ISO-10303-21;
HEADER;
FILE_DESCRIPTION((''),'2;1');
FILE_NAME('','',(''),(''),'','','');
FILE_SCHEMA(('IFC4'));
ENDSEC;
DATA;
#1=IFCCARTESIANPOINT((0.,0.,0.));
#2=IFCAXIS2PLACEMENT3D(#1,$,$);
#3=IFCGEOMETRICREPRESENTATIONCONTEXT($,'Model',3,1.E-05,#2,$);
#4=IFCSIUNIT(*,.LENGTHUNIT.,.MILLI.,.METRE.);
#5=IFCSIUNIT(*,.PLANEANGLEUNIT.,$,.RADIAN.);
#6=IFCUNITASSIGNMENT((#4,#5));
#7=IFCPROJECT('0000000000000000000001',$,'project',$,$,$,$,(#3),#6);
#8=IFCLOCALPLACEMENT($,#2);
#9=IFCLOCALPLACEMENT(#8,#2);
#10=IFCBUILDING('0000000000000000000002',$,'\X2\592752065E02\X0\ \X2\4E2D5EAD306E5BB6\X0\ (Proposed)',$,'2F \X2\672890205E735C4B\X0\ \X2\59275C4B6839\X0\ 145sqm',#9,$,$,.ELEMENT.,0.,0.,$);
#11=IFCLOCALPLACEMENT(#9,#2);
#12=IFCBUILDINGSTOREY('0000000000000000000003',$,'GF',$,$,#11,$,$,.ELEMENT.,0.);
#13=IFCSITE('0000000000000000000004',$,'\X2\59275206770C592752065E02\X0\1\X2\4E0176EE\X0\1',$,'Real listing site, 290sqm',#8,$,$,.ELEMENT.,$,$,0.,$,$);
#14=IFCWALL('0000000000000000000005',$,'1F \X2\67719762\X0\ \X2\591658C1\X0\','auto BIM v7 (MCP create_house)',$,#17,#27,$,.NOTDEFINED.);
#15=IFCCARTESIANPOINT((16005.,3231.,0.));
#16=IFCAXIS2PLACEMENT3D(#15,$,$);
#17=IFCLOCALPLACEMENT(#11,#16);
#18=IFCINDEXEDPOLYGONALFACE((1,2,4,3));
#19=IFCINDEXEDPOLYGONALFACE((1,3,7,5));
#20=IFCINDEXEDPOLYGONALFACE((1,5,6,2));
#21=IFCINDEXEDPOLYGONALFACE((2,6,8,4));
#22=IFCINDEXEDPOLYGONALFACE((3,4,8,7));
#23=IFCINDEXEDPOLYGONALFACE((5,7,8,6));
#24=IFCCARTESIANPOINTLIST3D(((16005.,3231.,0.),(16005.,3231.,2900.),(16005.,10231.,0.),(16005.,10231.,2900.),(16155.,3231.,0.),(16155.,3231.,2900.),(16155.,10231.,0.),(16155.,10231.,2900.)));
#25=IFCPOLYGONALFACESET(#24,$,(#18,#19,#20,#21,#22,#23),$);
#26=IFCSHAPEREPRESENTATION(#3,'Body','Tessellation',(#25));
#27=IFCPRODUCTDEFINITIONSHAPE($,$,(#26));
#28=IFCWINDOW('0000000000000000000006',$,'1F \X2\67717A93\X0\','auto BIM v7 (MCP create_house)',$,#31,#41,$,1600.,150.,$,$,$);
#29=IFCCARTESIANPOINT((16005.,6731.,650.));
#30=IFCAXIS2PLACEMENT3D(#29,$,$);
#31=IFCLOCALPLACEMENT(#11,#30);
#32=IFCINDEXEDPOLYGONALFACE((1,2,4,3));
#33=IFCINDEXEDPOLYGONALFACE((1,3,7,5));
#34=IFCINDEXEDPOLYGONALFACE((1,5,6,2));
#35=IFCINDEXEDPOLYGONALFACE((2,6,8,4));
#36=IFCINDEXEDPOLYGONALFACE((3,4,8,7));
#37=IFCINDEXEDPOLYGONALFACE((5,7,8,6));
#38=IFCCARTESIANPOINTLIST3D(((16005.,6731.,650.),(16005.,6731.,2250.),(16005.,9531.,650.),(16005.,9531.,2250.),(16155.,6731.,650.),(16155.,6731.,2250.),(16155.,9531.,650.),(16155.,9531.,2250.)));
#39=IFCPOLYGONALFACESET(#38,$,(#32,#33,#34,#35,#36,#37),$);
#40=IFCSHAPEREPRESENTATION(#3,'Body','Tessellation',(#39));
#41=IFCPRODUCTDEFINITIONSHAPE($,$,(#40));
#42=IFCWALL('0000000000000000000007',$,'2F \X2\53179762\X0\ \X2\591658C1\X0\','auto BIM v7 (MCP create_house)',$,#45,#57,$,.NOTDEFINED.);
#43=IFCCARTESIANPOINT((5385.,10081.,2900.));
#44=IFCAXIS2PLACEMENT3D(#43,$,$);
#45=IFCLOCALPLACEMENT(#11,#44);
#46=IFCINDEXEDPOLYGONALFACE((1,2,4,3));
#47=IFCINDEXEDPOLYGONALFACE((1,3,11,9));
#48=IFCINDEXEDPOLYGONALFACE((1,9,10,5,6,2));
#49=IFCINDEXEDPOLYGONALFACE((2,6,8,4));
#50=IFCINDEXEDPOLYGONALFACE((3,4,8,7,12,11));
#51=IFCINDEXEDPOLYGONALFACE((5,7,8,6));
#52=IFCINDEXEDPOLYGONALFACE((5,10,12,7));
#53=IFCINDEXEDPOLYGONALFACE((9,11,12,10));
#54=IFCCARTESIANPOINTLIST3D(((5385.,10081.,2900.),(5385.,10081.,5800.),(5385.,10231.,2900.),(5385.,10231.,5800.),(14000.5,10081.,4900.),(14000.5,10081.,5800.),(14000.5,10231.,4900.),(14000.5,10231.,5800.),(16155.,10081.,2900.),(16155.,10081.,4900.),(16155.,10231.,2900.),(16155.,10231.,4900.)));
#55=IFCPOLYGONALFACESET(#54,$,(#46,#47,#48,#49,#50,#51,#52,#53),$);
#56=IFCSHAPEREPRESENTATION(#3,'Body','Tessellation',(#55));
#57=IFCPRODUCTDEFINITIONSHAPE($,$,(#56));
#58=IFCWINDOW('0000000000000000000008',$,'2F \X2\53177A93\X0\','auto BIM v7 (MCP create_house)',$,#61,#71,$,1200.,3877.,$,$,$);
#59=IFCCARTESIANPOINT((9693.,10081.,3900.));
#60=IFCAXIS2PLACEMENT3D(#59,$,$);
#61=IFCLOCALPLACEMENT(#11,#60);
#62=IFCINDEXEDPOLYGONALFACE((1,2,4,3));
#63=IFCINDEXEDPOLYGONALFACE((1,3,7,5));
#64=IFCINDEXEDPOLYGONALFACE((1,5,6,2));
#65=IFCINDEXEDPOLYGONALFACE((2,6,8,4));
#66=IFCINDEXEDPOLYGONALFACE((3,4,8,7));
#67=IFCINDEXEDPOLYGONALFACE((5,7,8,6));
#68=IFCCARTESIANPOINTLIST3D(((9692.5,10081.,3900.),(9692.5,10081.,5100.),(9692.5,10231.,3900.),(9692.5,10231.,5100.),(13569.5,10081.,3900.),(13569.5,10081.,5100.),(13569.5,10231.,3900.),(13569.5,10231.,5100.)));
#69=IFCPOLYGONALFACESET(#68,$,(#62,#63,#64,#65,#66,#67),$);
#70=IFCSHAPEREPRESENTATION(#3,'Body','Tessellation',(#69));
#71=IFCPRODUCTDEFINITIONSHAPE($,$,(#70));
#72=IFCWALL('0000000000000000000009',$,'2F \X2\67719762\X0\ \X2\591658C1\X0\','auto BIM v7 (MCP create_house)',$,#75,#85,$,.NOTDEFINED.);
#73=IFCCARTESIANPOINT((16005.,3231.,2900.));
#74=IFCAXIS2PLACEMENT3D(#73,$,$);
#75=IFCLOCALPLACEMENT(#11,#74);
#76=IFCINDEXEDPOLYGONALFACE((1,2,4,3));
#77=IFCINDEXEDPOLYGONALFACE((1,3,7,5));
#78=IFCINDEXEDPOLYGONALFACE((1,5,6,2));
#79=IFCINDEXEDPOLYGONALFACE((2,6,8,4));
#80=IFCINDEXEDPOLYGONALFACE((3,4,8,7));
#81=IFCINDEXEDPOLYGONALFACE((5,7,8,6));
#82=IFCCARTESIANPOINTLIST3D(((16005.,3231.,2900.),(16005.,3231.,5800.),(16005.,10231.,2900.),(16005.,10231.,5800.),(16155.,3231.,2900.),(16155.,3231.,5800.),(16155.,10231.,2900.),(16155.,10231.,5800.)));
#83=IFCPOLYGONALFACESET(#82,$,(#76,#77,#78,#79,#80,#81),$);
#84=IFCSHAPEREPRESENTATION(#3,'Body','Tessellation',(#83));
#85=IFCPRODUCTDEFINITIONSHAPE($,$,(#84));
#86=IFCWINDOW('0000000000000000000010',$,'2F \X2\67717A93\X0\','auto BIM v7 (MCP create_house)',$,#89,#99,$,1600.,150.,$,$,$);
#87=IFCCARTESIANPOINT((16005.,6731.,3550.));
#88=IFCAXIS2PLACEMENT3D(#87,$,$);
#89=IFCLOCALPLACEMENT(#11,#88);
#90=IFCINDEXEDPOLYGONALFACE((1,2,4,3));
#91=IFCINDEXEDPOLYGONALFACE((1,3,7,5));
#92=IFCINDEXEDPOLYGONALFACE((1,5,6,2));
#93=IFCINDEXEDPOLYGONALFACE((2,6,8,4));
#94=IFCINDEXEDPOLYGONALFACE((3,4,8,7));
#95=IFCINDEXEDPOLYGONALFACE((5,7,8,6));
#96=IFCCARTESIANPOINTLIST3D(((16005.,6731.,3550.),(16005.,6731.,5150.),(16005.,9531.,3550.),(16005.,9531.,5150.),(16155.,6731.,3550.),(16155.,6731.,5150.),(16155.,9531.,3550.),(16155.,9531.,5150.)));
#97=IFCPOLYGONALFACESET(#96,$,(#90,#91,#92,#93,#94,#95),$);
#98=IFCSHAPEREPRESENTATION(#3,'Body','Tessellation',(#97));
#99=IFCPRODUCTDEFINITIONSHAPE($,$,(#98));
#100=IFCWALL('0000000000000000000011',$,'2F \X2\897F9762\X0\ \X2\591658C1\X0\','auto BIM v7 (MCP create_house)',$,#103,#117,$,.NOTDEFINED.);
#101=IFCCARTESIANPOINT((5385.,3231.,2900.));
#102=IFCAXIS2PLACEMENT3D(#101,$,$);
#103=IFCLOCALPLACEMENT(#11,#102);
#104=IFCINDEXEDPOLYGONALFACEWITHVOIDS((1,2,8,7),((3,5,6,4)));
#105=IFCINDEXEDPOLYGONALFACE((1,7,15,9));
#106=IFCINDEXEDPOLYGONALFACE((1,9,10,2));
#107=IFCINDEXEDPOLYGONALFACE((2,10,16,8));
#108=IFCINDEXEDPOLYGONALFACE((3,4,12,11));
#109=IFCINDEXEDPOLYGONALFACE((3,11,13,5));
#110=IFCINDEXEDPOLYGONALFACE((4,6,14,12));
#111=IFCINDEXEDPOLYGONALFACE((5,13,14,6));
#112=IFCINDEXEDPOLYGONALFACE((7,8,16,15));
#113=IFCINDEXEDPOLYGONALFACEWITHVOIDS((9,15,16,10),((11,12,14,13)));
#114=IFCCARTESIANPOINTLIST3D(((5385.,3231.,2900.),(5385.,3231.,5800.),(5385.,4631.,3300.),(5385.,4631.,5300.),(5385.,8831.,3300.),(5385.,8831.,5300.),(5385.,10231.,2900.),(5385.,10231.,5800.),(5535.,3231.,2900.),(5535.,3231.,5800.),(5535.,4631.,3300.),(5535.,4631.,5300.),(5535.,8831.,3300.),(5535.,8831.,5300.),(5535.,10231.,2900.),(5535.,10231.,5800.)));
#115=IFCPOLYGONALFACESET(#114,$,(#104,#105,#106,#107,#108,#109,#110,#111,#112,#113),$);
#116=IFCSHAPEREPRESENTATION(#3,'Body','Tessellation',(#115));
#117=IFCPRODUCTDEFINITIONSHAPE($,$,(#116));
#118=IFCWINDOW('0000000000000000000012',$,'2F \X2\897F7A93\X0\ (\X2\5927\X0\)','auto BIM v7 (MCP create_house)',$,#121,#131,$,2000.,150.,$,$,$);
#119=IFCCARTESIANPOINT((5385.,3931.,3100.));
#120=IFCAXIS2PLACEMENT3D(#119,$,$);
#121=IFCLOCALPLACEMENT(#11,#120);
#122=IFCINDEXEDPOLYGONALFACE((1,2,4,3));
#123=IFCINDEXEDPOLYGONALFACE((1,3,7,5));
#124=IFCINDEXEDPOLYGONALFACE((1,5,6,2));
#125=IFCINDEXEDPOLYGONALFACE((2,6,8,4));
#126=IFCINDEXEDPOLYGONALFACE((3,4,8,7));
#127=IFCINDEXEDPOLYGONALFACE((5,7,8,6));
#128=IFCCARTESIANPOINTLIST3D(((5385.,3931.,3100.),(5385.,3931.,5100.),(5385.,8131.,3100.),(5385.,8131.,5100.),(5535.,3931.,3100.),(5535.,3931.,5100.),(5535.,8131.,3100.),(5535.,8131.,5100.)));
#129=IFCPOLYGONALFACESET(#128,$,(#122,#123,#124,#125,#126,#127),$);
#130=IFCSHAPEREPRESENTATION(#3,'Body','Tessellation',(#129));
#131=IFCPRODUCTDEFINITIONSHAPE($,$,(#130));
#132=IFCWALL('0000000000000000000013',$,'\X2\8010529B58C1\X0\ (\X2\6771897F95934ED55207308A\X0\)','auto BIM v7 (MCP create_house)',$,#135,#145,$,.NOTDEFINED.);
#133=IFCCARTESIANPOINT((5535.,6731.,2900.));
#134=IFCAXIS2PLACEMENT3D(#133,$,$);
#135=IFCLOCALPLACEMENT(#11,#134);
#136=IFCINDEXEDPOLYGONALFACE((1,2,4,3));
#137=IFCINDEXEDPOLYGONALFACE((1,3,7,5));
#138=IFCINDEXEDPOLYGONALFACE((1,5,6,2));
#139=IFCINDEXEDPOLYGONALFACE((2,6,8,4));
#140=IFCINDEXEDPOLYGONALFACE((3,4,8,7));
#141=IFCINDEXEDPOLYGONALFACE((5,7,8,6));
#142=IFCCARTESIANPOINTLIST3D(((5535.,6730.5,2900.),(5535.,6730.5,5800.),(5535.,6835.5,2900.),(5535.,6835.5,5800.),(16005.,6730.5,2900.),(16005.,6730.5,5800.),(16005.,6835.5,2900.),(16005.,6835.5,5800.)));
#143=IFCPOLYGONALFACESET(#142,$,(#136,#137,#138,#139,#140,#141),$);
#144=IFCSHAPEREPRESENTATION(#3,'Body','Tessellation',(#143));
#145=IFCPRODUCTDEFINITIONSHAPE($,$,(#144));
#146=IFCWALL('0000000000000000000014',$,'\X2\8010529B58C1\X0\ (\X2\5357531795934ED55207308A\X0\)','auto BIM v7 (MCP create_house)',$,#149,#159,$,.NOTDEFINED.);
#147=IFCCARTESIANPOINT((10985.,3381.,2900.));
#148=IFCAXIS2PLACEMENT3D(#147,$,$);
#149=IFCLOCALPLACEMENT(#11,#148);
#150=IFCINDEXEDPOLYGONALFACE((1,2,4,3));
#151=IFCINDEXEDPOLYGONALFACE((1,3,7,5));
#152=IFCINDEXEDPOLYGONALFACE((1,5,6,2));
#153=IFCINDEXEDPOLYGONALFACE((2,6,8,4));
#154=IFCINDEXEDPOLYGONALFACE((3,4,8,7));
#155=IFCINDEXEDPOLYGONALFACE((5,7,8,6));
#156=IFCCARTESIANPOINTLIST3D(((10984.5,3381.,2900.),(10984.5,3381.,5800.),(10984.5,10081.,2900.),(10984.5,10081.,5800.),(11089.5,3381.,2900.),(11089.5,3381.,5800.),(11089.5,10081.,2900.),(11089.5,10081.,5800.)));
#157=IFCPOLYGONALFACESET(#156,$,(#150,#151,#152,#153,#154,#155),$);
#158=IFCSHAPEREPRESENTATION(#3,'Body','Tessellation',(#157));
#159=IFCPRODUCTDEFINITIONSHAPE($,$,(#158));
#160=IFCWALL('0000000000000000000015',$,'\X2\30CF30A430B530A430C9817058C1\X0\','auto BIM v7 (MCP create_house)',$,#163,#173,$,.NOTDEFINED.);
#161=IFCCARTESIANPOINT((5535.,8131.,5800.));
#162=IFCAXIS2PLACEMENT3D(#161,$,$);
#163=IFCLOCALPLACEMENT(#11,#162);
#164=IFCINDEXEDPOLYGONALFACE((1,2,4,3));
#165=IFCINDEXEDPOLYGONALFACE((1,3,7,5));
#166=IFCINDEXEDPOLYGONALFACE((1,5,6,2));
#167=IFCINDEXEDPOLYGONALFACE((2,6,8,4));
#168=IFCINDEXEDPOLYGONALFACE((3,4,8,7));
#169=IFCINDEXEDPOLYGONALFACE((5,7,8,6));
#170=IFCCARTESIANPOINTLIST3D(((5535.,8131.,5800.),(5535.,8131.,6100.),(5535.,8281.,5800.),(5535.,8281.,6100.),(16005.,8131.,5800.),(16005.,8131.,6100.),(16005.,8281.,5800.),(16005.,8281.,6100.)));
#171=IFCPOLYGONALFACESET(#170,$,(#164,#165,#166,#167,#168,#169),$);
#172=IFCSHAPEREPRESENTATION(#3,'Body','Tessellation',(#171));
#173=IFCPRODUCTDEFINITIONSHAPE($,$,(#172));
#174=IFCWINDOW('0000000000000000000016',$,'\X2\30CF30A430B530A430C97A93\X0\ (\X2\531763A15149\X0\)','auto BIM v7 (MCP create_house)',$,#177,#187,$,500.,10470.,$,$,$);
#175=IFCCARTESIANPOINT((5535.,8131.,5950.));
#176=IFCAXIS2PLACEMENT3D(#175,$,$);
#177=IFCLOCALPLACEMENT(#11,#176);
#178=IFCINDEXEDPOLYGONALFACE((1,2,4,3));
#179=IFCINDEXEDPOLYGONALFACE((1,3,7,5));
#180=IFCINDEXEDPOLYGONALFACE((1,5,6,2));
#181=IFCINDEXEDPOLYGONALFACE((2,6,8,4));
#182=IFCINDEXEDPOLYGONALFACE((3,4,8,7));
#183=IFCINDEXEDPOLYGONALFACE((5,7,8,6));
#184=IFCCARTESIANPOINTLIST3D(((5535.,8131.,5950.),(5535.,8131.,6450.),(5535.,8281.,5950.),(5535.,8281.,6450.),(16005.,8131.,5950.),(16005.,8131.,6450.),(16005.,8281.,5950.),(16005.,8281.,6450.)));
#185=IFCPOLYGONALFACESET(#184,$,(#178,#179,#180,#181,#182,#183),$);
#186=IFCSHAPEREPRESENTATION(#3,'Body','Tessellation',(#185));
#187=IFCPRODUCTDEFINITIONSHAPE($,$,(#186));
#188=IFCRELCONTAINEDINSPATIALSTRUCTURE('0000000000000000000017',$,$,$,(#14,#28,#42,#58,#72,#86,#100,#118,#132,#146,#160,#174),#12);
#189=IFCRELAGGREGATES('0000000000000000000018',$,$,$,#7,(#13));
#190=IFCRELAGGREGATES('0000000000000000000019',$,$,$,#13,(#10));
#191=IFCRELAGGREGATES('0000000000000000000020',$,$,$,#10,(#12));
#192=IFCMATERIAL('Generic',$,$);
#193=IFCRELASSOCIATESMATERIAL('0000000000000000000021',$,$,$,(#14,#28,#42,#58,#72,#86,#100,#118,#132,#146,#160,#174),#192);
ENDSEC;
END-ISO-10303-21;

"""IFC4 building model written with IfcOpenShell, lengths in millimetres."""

from ifc_helpers import new_model, si_unit, frame, frame_2d, origin, place, context, project, spatial, rectangle, extrude, material, element, fill, save


model = new_model("IFC4")

# Units and contexts
model_context = context("Model", 3, precision=1e-05, world=origin())
ifc_project = project(units=[si_unit("LENGTHUNIT", "METRE", prefix="MILLI"), si_unit("PLANEANGLEUNIT", "RADIAN")], contexts=[model_context])

# Site, building, storey
site_placement = place(None, origin())
site = spatial("IfcSite", under=ifc_project, at=site_placement, Name="大分県大分市1丁目1", ObjectType="Real listing site, 290sqm", CompositionType="ELEMENT", RefElevation=0.0)
building_placement = place(site_placement, origin())
building = spatial("IfcBuilding", under=site, at=building_placement, Name="大分市 中庭の家 (Proposed)", ObjectType="2F 木造平屋 大屋根 145sqm", CompositionType="ELEMENT", ElevationOfRefHeight=0.0, ElevationOfTerrain=0.0)
storey_placement = place(building_placement, origin())
storey = spatial("IfcBuildingStorey", under=building, at=storey_placement, Name="GF", CompositionType="ELEMENT", Elevation=0.0)

# Shared definitions
ifc_material = material(Name="Generic")

# Wall, opening, window
wall_1_placement = place(storey_placement, frame((16005.0, 3231.0, 0.0)))
wall_1 = element("IfcWall", 1, at=wall_1_placement, inside=storey, material=ifc_material, Name="1F 東面 外壁", Description="auto BIM v7 (MCP create_house)", PredefinedType="NOTDEFINED", context=model_context, shape_type="SweptSolid", body=[
    extrude(rectangle(XDim=150.0, YDim=7000.0, at=frame_2d((75.0, 3500.0))), frame((16005.0, 3231.0, 0.0)), (0.0, 0.0, 1.0), 2900.0),
])
opening_1_placement = place(storey_placement, frame((16005.0, 6731.0, 650.0)))
opening_1 = element("IfcOpeningElement", 2, at=opening_1_placement, cuts=wall_1, PredefinedType="NOTDEFINED", context=model_context, shape_type="SweptSolid", body=[
    extrude(rectangle(XDim=150.0, YDim=2800.0, at=frame_2d((75.0, 1400.0))), frame((16005.0, 6731.0, 650.0)), (0.0, 0.0, 1.0), 1600.0),
])
window_1_placement = place(storey_placement, frame((16005.0, 6731.0, 650.0)))
window_1 = element("IfcWindow", 3, at=window_1_placement, inside=storey, material=ifc_material, Name="1F 東窓", Description="auto BIM v7 (MCP create_house)", OverallHeight=1600.0, OverallWidth=150.0, context=model_context, shape_type="SweptSolid", body=[
    extrude(rectangle(XDim=150.0, YDim=2800.0, at=frame_2d((75.0, 1400.0))), frame((16005.0, 6731.0, 650.0)), (0.0, 0.0, 1.0), 1600.0),
])
fill(opening_1, window_1)

# Walls, openings, windows
wall_2_placement = place(storey_placement, frame((5385.0, 10081.0, 2900.0)))
wall_2 = element("IfcWall", 4, at=wall_2_placement, inside=storey, material=ifc_material, Name="2F 北面 外壁", Description="auto BIM v7 (MCP create_house)", PredefinedType="NOTDEFINED", context=model_context, shape_type="SweptSolid", body=[
    extrude(rectangle(XDim=10770.0, YDim=150.0, at=frame_2d((5385.0, 75.0))), frame((5385.0, 10081.0, 2900.0)), (0.0, 0.0, 1.0), 2900.0),
])
opening_2_placement = place(storey_placement, frame((9693.0, 10081.0, 3900.0)))
opening_2 = element("IfcOpeningElement", 5, at=opening_2_placement, cuts=wall_2, PredefinedType="NOTDEFINED", context=model_context, shape_type="SweptSolid", body=[
    extrude(rectangle(XDim=3877.0, YDim=150.0, at=frame_2d((1938.0, 75.0))), frame((9693.0, 10081.0, 3900.0)), (0.0, 0.0, 1.0), 1200.0),
])
window_2_placement = place(storey_placement, frame((9693.0, 10081.0, 3900.0)))
window_2 = element("IfcWindow", 6, at=window_2_placement, inside=storey, material=ifc_material, Name="2F 北窓", Description="auto BIM v7 (MCP create_house)", OverallHeight=1200.0, OverallWidth=3877.0, context=model_context, shape_type="SweptSolid", body=[
    extrude(rectangle(XDim=3877.0, YDim=150.0, at=frame_2d((1938.0, 75.0))), frame((9693.0, 10081.0, 3900.0)), (0.0, 0.0, 1.0), 1200.0),
])
fill(opening_2, window_2)
wall_3_placement = place(storey_placement, frame((16005.0, 3231.0, 2900.0)))
wall_3 = element("IfcWall", 7, at=wall_3_placement, inside=storey, material=ifc_material, Name="2F 東面 外壁", Description="auto BIM v7 (MCP create_house)", PredefinedType="NOTDEFINED", context=model_context, shape_type="SweptSolid", body=[
    extrude(rectangle(XDim=150.0, YDim=7000.0, at=frame_2d((75.0, 3500.0))), frame((16005.0, 3231.0, 2900.0)), (0.0, 0.0, 1.0), 2900.0),
])
opening_3_placement = place(storey_placement, frame((16005.0, 6731.0, 3550.0)))
opening_3 = element("IfcOpeningElement", 8, at=opening_3_placement, cuts=wall_3, PredefinedType="NOTDEFINED", context=model_context, shape_type="SweptSolid", body=[
    extrude(rectangle(XDim=150.0, YDim=2800.0, at=frame_2d((75.0, 1400.0))), frame((16005.0, 6731.0, 3550.0)), (0.0, 0.0, 1.0), 1600.0),
])
window_3_placement = place(storey_placement, frame((16005.0, 6731.0, 3550.0)))
window_3 = element("IfcWindow", 9, at=window_3_placement, inside=storey, material=ifc_material, Name="2F 東窓", Description="auto BIM v7 (MCP create_house)", OverallHeight=1600.0, OverallWidth=150.0, context=model_context, shape_type="SweptSolid", body=[
    extrude(rectangle(XDim=150.0, YDim=2800.0, at=frame_2d((75.0, 1400.0))), frame((16005.0, 6731.0, 3550.0)), (0.0, 0.0, 1.0), 1600.0),
])
fill(opening_3, window_3)
wall_4_placement = place(storey_placement, frame((5385.0, 3231.0, 2900.0)))
wall_4 = element("IfcWall", 10, at=wall_4_placement, inside=storey, material=ifc_material, Name="2F 西面 外壁", Description="auto BIM v7 (MCP create_house)", PredefinedType="NOTDEFINED", context=model_context, shape_type="SweptSolid", body=[
    extrude(rectangle(XDim=150.0, YDim=7000.0, at=frame_2d((75.0, 3500.0))), frame((5385.0, 3231.0, 2900.0)), (0.0, 0.0, 1.0), 2900.0),
])
opening_4_placement = place(storey_placement, frame((5385.0, 3931.0, 3100.0)))
opening_4 = element("IfcOpeningElement", 11, at=opening_4_placement, cuts=wall_4, PredefinedType="NOTDEFINED", context=model_context, shape_type="SweptSolid", body=[
    extrude(rectangle(XDim=150.0, YDim=4200.0, at=frame_2d((75.0, 2100.0))), frame((5385.0, 3931.0, 3100.0)), (0.0, 0.0, 1.0), 2000.0),
])
window_4_placement = place(storey_placement, frame((5385.0, 3931.0, 3100.0)))
window_4 = element("IfcWindow", 12, at=window_4_placement, inside=storey, material=ifc_material, Name="2F 西窓 (大)", Description="auto BIM v7 (MCP create_house)", OverallHeight=2000.0, OverallWidth=150.0, context=model_context, shape_type="SweptSolid", body=[
    extrude(rectangle(XDim=150.0, YDim=4200.0, at=frame_2d((75.0, 2100.0))), frame((5385.0, 3931.0, 3100.0)), (0.0, 0.0, 1.0), 2000.0),
])
fill(opening_4, window_4)

# Walls
wall_5_placement = place(storey_placement, frame((5535.0, 6731.0, 2900.0)))
element("IfcWall", 13, at=wall_5_placement, inside=storey, material=ifc_material, Name="耐力壁 (東西間仕切り)", Description="auto BIM v7 (MCP create_house)", PredefinedType="NOTDEFINED", context=model_context, shape_type="SweptSolid", body=[
    extrude(rectangle(XDim=10470.0, YDim=105.0, at=frame_2d((5235.0, 52.0))), frame((5535.0, 6731.0, 2900.0)), (0.0, 0.0, 1.0), 2900.0),
])
wall_6_placement = place(storey_placement, frame((10985.0, 3381.0, 2900.0)))
element("IfcWall", 14, at=wall_6_placement, inside=storey, material=ifc_material, Name="耐力壁 (南北間仕切り)", Description="auto BIM v7 (MCP create_house)", PredefinedType="NOTDEFINED", context=model_context, shape_type="SweptSolid", body=[
    extrude(rectangle(XDim=105.0, YDim=6700.0, at=frame_2d((52.0, 3350.0))), frame((10985.0, 3381.0, 2900.0)), (0.0, 0.0, 1.0), 2900.0),
])

# Wall, opening, window
wall_7_placement = place(storey_placement, frame((5535.0, 8131.0, 5800.0)))
wall_7 = element("IfcWall", 15, at=wall_7_placement, inside=storey, material=ifc_material, Name="ハイサイド腰壁", Description="auto BIM v7 (MCP create_house)", PredefinedType="NOTDEFINED", context=model_context, shape_type="SweptSolid", body=[
    extrude(rectangle(XDim=10470.0, YDim=150.0, at=frame_2d((5235.0, 75.0))), frame((5535.0, 8131.0, 5800.0)), (0.0, 0.0, 1.0), 700.0),
])
opening_5_placement = place(storey_placement, frame((5535.0, 8131.0, 5950.0)))
opening_5 = element("IfcOpeningElement", 16, at=opening_5_placement, cuts=wall_7, PredefinedType="NOTDEFINED", context=model_context, shape_type="SweptSolid", body=[
    extrude(rectangle(XDim=10470.0, YDim=150.0, at=frame_2d((5235.0, 75.0))), frame((5535.0, 8131.0, 5950.0)), (0.0, 0.0, 1.0), 500.0),
])
window_5_placement = place(storey_placement, frame((5535.0, 8131.0, 5950.0)))
window_5 = element("IfcWindow", 17, at=window_5_placement, inside=storey, material=ifc_material, Name="ハイサイド窓 (北採光)", Description="auto BIM v7 (MCP create_house)", OverallHeight=500.0, OverallWidth=10470.0, context=model_context, shape_type="SweptSolid", body=[
    extrude(rectangle(XDim=10470.0, YDim=150.0, at=frame_2d((5235.0, 75.0))), frame((5535.0, 8131.0, 5950.0)), (0.0, 0.0, 1.0), 500.0),
])
fill(opening_5, window_5)

save(model, "model.ifc")
